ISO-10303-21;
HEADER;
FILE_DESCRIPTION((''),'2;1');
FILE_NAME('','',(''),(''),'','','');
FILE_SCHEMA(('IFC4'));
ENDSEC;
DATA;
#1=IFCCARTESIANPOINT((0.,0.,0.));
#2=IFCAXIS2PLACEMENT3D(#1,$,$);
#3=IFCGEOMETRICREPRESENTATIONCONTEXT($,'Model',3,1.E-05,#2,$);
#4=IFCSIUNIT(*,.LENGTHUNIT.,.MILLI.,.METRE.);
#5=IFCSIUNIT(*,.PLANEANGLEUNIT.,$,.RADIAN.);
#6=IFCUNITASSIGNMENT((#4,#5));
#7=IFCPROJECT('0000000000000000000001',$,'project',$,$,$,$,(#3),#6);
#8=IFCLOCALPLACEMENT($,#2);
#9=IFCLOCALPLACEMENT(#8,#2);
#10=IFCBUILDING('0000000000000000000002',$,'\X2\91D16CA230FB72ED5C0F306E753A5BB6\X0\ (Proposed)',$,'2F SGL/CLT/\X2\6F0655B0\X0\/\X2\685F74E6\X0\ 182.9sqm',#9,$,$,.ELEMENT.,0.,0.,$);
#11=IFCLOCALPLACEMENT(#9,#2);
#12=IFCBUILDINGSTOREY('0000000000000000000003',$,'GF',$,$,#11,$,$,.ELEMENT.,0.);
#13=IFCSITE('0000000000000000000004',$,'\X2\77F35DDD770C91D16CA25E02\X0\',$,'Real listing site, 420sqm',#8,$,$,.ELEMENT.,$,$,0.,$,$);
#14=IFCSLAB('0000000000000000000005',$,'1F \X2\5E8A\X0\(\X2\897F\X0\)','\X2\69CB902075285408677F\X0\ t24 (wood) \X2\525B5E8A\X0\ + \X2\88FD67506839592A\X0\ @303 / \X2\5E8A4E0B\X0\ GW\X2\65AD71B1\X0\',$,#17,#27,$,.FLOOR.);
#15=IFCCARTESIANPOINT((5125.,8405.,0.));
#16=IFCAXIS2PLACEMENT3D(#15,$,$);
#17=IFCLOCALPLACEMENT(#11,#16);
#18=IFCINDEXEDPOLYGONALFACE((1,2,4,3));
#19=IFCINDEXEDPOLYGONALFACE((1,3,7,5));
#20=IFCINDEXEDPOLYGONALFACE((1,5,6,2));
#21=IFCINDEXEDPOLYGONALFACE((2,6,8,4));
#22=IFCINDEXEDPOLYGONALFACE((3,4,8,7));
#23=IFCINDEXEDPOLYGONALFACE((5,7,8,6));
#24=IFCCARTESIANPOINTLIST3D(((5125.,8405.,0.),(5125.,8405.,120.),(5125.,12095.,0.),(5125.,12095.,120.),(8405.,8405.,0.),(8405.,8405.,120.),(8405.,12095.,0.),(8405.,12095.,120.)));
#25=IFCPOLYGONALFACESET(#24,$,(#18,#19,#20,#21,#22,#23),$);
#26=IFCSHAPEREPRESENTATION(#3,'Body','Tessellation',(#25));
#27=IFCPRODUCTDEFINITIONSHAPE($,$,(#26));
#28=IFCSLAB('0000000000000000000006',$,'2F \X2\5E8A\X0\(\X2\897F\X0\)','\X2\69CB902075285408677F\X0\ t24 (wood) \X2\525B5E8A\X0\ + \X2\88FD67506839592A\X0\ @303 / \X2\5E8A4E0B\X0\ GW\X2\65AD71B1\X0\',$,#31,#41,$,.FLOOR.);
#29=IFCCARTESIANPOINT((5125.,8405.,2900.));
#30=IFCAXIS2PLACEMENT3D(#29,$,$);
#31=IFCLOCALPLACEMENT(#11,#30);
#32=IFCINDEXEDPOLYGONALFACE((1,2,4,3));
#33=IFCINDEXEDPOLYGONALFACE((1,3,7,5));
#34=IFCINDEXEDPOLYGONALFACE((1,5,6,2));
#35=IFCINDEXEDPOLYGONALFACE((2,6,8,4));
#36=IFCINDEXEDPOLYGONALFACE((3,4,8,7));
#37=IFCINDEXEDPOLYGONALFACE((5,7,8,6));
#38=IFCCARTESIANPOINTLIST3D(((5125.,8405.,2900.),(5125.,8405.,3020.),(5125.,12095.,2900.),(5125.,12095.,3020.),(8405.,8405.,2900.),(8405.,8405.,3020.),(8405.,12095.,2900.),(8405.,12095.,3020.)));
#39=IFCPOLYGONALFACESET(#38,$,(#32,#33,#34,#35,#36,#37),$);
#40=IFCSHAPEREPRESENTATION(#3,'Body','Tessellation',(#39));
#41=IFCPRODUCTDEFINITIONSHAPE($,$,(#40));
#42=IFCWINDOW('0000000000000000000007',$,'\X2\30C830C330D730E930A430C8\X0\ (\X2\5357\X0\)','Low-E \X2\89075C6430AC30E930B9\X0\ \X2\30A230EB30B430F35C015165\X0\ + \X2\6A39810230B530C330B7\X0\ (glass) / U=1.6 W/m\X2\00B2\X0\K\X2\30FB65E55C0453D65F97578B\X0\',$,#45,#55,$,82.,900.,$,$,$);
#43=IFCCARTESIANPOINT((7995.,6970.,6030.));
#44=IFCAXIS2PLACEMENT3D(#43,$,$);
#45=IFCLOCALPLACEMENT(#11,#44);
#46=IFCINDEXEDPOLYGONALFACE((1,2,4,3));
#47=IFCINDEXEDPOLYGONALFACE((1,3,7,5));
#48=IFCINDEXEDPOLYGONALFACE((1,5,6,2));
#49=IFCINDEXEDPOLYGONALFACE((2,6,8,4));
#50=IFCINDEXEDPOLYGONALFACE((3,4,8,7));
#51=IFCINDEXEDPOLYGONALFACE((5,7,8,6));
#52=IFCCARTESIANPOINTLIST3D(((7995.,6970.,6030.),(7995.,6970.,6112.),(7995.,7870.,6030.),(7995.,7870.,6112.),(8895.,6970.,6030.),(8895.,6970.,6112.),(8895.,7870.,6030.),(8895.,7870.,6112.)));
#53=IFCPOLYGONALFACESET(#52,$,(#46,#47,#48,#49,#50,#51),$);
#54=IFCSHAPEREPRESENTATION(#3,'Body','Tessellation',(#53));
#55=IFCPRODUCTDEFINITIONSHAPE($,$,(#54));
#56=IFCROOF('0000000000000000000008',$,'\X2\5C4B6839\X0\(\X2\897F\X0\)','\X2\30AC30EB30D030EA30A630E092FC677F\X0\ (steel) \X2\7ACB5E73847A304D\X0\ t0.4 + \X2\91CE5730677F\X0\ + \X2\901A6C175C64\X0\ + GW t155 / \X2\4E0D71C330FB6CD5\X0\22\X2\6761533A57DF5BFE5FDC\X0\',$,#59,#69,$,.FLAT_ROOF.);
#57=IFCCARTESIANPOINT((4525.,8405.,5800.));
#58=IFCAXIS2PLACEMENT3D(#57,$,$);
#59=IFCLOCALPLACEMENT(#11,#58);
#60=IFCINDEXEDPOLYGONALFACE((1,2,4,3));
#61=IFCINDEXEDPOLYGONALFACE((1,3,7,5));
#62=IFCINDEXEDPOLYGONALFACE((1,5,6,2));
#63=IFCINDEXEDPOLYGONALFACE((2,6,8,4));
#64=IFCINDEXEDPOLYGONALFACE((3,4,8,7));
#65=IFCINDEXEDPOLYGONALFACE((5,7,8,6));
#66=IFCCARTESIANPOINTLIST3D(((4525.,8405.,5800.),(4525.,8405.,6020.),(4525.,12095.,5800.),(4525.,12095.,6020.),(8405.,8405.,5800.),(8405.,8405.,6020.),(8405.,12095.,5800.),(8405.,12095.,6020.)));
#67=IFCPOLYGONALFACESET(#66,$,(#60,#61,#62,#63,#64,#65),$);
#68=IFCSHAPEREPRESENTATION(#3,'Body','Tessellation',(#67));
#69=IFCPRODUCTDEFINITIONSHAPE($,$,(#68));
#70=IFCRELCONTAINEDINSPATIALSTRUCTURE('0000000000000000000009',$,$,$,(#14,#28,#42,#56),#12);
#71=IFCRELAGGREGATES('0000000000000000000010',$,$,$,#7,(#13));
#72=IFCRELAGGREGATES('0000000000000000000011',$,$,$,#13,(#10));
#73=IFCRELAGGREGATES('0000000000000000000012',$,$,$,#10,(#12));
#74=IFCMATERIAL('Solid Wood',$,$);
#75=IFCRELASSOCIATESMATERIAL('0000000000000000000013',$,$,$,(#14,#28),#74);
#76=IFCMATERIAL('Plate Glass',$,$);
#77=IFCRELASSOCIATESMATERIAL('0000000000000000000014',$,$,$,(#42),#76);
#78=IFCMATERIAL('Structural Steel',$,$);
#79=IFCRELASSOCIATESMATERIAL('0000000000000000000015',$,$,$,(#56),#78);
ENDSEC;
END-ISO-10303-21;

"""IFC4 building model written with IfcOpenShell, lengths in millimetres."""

from ifc_helpers import new_model, si_unit, frame, frame_2d, origin, place, context, project, spatial, rectangle, extrude, material, element, save


model = new_model("IFC4")

# Units and contexts
model_context = context("Model", 3, precision=1e-05, world=origin())
ifc_project = project(units=[si_unit("LENGTHUNIT", "METRE", prefix="MILLI"), si_unit("PLANEANGLEUNIT", "RADIAN")], contexts=[model_context])

# Site, building, storey
site_placement = place(None, origin())
site = spatial("IfcSite", under=ifc_project, at=site_placement, Name="石川県金沢市", ObjectType="Real listing site, 420sqm", CompositionType="ELEMENT", RefElevation=0.0)
building_placement = place(site_placement, origin())
building = spatial("IfcBuilding", under=site, at=building_placement, Name="金沢・狭小の町家 (Proposed)", ObjectType="2F SGL/CLT/漆喰/桟瓦 182.9sqm", CompositionType="ELEMENT", ElevationOfRefHeight=0.0, ElevationOfTerrain=0.0)
storey_placement = place(building_placement, origin())
storey = spatial("IfcBuildingStorey", under=building, at=storey_placement, Name="GF", CompositionType="ELEMENT", Elevation=0.0)

# Shared definitions
ifc_material_1 = material(Name="Solid Wood")

# Slabs
slab_1_placement = place(storey_placement, frame((5125.0, 8405.0, 0.0)))
element("IfcSlab", 1, at=slab_1_placement, inside=storey, material=ifc_material_1, Name="1F 床(西)", Description="構造用合板 t24 (wood) 剛床 + 製材根太 @303 / 床下 GW断熱", PredefinedType="FLOOR", context=model_context, shape_type="SweptSolid", body=[
    extrude(rectangle(XDim=3280.0, YDim=3690.0, at=frame_2d((1640.0, 1845.0))), frame((5125.0, 8405.0, 0.0)), (0.0, 0.0, 1.0), 120.0),
])
slab_2_placement = place(storey_placement, frame((5125.0, 8405.0, 2900.0)))
element("IfcSlab", 2, at=slab_2_placement, inside=storey, material=ifc_material_1, Name="2F 床(西)", Description="構造用合板 t24 (wood) 剛床 + 製材根太 @303 / 床下 GW断熱", PredefinedType="FLOOR", context=model_context, shape_type="SweptSolid", body=[
    extrude(rectangle(XDim=3280.0, YDim=3690.0, at=frame_2d((1640.0, 1845.0))), frame((5125.0, 8405.0, 2900.0)), (0.0, 0.0, 1.0), 120.0),
])

# Window
ifc_material_2 = material(Name="Plate Glass")
window_placement = place(storey_placement, frame((7995.0, 6970.0, 6030.0)))
element("IfcWindow", 3, at=window_placement, inside=storey, material=ifc_material_2, Name="トップライト (南)", Description="Low-E 複層ガラス アルゴン封入 + 樹脂サッシ (glass) / U=1.6 W/m²K・日射取得型", OverallHeight=82.0, OverallWidth=900.0, context=model_context, shape_type="SweptSolid", body=[
    extrude(rectangle(XDim=900.0, YDim=900.0, at=frame_2d((450.0, 450.0))), frame((7995.0, 6970.0, 6030.0)), (0.0, 0.0, 1.0), 82.0),
])

# Roof
ifc_material_3 = material(Name="Structural Steel")
for number, where, name in (
    (4, (4525.0, 8405.0, 5800.0), "屋根(西)"),
):
    element("IfcRoof", number, at=place(storey_placement, frame(where)), inside=storey, material=ifc_material_3, Name=name, Description="ガルバリウム鋼板 (steel) 立平葺き t0.4 + 野地板 + 通気層 + GW t155 / 不燃・法22条区域対応", PredefinedType="FLAT_ROOF", context=model_context, shape_type="SweptSolid", body=[
        extrude(rectangle(XDim=3880.0, YDim=3690.0, at=frame_2d((1940.0, 1845.0))), frame((4525.0, 8405.0, 5800.0)), (0.0, 0.0, 1.0), 220.0),
    ])

save(model, "model.ifc")
